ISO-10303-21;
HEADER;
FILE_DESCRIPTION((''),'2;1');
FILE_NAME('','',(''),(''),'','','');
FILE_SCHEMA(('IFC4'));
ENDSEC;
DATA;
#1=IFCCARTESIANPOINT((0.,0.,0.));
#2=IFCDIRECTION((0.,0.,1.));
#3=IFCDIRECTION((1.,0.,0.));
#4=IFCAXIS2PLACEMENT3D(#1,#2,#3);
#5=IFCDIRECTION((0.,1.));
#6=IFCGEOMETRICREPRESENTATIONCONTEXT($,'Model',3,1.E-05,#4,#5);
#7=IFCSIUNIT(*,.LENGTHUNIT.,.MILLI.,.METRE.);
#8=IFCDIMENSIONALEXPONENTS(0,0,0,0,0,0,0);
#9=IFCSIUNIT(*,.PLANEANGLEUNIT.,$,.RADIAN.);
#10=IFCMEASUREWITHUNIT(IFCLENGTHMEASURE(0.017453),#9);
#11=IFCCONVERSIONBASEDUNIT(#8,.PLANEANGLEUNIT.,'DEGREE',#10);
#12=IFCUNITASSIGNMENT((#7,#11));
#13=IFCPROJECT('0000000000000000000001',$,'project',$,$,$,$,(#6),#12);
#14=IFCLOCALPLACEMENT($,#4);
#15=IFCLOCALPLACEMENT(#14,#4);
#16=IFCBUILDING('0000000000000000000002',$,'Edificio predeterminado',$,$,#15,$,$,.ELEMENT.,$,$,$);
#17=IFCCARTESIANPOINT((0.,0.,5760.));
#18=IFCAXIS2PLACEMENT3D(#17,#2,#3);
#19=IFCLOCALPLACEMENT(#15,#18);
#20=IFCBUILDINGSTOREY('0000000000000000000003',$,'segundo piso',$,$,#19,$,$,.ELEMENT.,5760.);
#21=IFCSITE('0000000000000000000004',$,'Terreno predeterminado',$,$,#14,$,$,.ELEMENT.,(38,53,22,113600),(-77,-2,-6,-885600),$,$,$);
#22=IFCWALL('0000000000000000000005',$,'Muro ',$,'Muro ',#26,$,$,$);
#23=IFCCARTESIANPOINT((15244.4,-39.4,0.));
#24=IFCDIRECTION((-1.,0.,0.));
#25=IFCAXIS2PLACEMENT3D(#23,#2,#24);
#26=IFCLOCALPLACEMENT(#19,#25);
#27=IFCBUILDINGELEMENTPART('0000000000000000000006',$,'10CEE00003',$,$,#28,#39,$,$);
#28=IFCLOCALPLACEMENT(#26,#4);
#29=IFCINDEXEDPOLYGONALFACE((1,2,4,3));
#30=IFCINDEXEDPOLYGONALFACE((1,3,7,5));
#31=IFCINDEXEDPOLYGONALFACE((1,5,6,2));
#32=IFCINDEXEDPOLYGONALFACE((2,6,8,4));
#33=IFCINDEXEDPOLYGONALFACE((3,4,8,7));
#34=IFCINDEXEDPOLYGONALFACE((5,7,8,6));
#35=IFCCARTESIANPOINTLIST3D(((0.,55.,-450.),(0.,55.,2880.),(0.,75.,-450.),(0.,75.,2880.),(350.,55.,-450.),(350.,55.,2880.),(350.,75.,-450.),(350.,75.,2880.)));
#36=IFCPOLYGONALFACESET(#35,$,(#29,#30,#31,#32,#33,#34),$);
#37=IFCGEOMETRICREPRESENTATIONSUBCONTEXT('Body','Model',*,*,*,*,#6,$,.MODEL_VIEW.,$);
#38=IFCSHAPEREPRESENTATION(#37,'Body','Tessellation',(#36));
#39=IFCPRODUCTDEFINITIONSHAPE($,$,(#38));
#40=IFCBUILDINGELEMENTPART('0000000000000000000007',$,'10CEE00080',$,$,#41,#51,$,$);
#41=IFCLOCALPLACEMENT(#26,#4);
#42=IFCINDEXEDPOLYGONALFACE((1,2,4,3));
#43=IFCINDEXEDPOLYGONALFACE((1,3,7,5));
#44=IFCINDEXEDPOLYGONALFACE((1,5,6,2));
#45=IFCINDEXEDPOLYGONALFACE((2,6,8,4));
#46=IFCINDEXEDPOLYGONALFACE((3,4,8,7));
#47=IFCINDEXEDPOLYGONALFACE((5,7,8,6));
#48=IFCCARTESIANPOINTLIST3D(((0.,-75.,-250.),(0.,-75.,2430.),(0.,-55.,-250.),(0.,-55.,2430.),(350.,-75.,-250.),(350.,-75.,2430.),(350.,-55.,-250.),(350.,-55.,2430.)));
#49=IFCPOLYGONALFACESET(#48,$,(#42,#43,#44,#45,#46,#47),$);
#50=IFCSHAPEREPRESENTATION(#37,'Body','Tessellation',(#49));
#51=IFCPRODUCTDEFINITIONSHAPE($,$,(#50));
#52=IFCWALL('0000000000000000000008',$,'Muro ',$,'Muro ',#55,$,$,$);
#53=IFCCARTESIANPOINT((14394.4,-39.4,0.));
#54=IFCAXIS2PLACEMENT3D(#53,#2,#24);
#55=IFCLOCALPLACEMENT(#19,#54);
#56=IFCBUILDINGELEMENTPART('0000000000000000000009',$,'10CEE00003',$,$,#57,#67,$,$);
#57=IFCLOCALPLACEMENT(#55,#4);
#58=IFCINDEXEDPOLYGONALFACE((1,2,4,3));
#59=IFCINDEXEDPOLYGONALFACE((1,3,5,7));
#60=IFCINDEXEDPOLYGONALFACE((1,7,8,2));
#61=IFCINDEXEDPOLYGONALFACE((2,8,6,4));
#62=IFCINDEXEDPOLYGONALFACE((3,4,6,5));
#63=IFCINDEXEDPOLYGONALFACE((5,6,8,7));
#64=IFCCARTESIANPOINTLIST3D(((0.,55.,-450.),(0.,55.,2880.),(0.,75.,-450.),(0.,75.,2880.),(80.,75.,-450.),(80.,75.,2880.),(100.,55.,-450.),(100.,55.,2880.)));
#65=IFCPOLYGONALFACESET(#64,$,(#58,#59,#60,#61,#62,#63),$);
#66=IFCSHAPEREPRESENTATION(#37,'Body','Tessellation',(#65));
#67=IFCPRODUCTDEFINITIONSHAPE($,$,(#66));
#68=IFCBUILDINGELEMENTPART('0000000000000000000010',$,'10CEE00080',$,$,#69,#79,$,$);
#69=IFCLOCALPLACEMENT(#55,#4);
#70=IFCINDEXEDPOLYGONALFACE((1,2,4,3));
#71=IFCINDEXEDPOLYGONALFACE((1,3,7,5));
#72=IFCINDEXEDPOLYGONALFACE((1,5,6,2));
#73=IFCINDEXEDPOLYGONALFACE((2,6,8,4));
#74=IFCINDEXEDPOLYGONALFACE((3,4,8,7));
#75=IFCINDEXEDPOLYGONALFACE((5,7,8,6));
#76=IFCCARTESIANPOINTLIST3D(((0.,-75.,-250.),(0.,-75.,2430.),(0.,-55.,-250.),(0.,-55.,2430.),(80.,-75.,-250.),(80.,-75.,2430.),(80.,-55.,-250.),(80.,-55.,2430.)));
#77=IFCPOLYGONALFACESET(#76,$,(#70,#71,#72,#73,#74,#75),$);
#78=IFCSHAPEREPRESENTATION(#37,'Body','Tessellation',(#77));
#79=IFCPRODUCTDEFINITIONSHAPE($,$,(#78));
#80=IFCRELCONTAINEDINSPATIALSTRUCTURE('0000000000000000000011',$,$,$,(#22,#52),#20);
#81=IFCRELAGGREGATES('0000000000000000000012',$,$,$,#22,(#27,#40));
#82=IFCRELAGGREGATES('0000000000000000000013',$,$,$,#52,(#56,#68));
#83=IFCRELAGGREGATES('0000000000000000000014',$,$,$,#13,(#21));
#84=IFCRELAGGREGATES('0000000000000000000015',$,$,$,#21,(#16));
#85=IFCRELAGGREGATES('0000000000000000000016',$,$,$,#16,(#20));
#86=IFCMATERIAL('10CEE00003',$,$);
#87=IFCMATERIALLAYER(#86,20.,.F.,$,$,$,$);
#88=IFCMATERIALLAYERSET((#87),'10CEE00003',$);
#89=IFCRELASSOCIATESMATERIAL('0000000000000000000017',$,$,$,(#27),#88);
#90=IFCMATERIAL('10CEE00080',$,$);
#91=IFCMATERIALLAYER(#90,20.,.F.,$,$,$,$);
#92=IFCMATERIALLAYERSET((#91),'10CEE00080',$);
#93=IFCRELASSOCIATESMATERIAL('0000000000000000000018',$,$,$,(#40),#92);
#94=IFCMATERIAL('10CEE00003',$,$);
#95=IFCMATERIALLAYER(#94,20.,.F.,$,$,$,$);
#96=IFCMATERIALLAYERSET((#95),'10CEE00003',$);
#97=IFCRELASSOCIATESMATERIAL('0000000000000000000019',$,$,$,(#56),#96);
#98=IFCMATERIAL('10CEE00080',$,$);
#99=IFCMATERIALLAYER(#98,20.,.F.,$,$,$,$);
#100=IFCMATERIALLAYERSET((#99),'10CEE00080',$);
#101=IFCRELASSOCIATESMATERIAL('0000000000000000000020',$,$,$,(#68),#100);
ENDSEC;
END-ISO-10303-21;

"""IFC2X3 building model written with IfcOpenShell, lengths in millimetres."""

from ifc_helpers import new_model, entity, si_unit, converted_unit, direction, frame, origin_with_axes, place, context, subcontext, project, spatial, polyline, outline, extrude, material, layer, layer_set, layer_usage, element, aggregate, save


model = new_model("IFC2X3")

# Units and contexts
model_context = context("Model", 3, precision=1e-05, world=origin_with_axes(), true_north=direction((0.0, 1.0)))
body_context = subcontext(model_context, "Body", "Model", "MODEL_VIEW")
ifc_project = project(units=[si_unit("LENGTHUNIT", "METRE", prefix="MILLI"), converted_unit("PLANEANGLEUNIT", "DEGREE", entity("IfcLengthMeasure", 0.017453), si_unit("PLANEANGLEUNIT", "RADIAN"), dimensions=[0, 0, 0, 0, 0, 0, 0])], contexts=[model_context])

# Site, building, storey
site_placement = place(None, origin_with_axes())
site = spatial("IfcSite", under=ifc_project, at=site_placement, Name="Terreno predeterminado", CompositionType="ELEMENT", RefLatitude=(38, 53, 22, 113600), RefLongitude=(-77, -2, -6, -885600))
building_placement = place(site_placement, origin_with_axes())
building = spatial("IfcBuilding", under=site, at=building_placement, Name="Edificio predeterminado", CompositionType="ELEMENT")
storey_placement = place(building_placement, frame((0.0, 0.0, 5760.0), z_axis=(0.0, 0.0, 1.0), x_axis=(1.0, 0.0, 0.0)))
storey = spatial("IfcBuildingStorey", under=building, at=storey_placement, Name="segundo piso", CompositionType="ELEMENT", Elevation=5760.0)

# Walls, building element parts
wall_1_placement = place(storey_placement, frame((15244.4, -39.4, 0.0), z_axis=(0.0, 0.0, 1.0), x_axis=(-1.0, 0.0, 0.0)))
wall_1 = element("IfcWall", 1, at=wall_1_placement, inside=storey, Name="Muro ", ObjectType="Muro ")
ifc_material_1 = material(Name="10CEE00003")
ifc_layer_1 = layer(ifc_material_1, 20.0, ventilated=False)
ifc_layer_set_1 = layer_set([ifc_layer_1], Name="10CEE00003")
ifc_layer_usage_1 = layer_usage(ifc_layer_set_1, "AXIS2", "NEGATIVE", -75.0)
building_element_part_1_placement = place(wall_1_placement, origin_with_axes())
building_element_part_1 = element("IfcBuildingElementPart", 2, at=building_element_part_1_placement, material=ifc_layer_usage_1, Name="10CEE00003", context=body_context, shape_type="SweptSolid", body=[
    extrude(outline(polyline([(350.0, 75.0), (350.0, 55.0), (0.0, 55.0), (0.0, 75.0), (350.0, 75.0)])), frame((0.0, 0.0, -450.0), z_axis=(0.0, 0.0, 1.0), x_axis=(1.0, 0.0, 0.0)), (0.0, 0.0, 1.0), 3330.0),
])
ifc_material_2 = material(Name="10CEE00080")
ifc_layer_2 = layer(ifc_material_2, 20.0, ventilated=False)
ifc_layer_set_2 = layer_set([ifc_layer_2], Name="10CEE00080")
ifc_layer_usage_2 = layer_usage(ifc_layer_set_2, "AXIS2", "NEGATIVE", 55.0)
building_element_part_2_placement = place(wall_1_placement, origin_with_axes())
building_element_part_2 = element("IfcBuildingElementPart", 3, at=building_element_part_2_placement, material=ifc_layer_usage_2, Name="10CEE00080", context=body_context, shape_type="SweptSolid", body=[
    extrude(outline(polyline([(350.0, -55.0), (350.0, -75.0), (0.0, -75.0), (0.0, -55.0), (350.0, -55.0)])), frame((0.0, 0.0, -250.0), z_axis=(0.0, 0.0, 1.0), x_axis=(1.0, 0.0, 0.0)), (0.0, 0.0, 1.0), 2680.0),
])
aggregate(wall_1, [building_element_part_1, building_element_part_2])
wall_2_placement = place(storey_placement, frame((14394.4, -39.4, 0.0), z_axis=(0.0, 0.0, 1.0), x_axis=(-1.0, 0.0, 0.0)))
wall_2 = element("IfcWall", 4, at=wall_2_placement, inside=storey, Name="Muro ", ObjectType="Muro ")
ifc_material_3 = material(Name="10CEE00003")
ifc_layer_3 = layer(ifc_material_3, 20.0, ventilated=False)
ifc_layer_set_3 = layer_set([ifc_layer_3], Name="10CEE00003")
ifc_layer_usage_3 = layer_usage(ifc_layer_set_3, "AXIS2", "NEGATIVE", -75.0)
building_element_part_3_placement = place(wall_2_placement, origin_with_axes())
building_element_part_3 = element("IfcBuildingElementPart", 5, at=building_element_part_3_placement, material=ifc_layer_usage_3, Name="10CEE00003", context=body_context, shape_type="SweptSolid", body=[
    extrude(outline(polyline([(80.0, 75.0), (100.0, 55.0), (0.0, 55.0), (0.0, 75.0), (80.0, 75.0)])), frame((0.0, 0.0, -450.0), z_axis=(0.0, 0.0, 1.0), x_axis=(1.0, 0.0, 0.0)), (0.0, 0.0, 1.0), 3330.0),
])
ifc_material_4 = material(Name="10CEE00080")
ifc_layer_4 = layer(ifc_material_4, 20.0, ventilated=False)
ifc_layer_set_4 = layer_set([ifc_layer_4], Name="10CEE00080")
ifc_layer_usage_4 = layer_usage(ifc_layer_set_4, "AXIS2", "NEGATIVE", 55.0)
building_element_part_4_placement = place(wall_2_placement, origin_with_axes())
building_element_part_4 = element("IfcBuildingElementPart", 6, at=building_element_part_4_placement, material=ifc_layer_usage_4, Name="10CEE00080", context=body_context, shape_type="SweptSolid", body=[
    extrude(outline(polyline([(80.0, -55.0), (80.0, -75.0), (0.0, -75.0), (0.0, -55.0), (80.0, -55.0)])), frame((0.0, 0.0, -250.0), z_axis=(0.0, 0.0, 1.0), x_axis=(1.0, 0.0, 0.0)), (0.0, 0.0, 1.0), 2680.0),
])
aggregate(wall_2, [building_element_part_3, building_element_part_4])

save(model, "model.ifc")
